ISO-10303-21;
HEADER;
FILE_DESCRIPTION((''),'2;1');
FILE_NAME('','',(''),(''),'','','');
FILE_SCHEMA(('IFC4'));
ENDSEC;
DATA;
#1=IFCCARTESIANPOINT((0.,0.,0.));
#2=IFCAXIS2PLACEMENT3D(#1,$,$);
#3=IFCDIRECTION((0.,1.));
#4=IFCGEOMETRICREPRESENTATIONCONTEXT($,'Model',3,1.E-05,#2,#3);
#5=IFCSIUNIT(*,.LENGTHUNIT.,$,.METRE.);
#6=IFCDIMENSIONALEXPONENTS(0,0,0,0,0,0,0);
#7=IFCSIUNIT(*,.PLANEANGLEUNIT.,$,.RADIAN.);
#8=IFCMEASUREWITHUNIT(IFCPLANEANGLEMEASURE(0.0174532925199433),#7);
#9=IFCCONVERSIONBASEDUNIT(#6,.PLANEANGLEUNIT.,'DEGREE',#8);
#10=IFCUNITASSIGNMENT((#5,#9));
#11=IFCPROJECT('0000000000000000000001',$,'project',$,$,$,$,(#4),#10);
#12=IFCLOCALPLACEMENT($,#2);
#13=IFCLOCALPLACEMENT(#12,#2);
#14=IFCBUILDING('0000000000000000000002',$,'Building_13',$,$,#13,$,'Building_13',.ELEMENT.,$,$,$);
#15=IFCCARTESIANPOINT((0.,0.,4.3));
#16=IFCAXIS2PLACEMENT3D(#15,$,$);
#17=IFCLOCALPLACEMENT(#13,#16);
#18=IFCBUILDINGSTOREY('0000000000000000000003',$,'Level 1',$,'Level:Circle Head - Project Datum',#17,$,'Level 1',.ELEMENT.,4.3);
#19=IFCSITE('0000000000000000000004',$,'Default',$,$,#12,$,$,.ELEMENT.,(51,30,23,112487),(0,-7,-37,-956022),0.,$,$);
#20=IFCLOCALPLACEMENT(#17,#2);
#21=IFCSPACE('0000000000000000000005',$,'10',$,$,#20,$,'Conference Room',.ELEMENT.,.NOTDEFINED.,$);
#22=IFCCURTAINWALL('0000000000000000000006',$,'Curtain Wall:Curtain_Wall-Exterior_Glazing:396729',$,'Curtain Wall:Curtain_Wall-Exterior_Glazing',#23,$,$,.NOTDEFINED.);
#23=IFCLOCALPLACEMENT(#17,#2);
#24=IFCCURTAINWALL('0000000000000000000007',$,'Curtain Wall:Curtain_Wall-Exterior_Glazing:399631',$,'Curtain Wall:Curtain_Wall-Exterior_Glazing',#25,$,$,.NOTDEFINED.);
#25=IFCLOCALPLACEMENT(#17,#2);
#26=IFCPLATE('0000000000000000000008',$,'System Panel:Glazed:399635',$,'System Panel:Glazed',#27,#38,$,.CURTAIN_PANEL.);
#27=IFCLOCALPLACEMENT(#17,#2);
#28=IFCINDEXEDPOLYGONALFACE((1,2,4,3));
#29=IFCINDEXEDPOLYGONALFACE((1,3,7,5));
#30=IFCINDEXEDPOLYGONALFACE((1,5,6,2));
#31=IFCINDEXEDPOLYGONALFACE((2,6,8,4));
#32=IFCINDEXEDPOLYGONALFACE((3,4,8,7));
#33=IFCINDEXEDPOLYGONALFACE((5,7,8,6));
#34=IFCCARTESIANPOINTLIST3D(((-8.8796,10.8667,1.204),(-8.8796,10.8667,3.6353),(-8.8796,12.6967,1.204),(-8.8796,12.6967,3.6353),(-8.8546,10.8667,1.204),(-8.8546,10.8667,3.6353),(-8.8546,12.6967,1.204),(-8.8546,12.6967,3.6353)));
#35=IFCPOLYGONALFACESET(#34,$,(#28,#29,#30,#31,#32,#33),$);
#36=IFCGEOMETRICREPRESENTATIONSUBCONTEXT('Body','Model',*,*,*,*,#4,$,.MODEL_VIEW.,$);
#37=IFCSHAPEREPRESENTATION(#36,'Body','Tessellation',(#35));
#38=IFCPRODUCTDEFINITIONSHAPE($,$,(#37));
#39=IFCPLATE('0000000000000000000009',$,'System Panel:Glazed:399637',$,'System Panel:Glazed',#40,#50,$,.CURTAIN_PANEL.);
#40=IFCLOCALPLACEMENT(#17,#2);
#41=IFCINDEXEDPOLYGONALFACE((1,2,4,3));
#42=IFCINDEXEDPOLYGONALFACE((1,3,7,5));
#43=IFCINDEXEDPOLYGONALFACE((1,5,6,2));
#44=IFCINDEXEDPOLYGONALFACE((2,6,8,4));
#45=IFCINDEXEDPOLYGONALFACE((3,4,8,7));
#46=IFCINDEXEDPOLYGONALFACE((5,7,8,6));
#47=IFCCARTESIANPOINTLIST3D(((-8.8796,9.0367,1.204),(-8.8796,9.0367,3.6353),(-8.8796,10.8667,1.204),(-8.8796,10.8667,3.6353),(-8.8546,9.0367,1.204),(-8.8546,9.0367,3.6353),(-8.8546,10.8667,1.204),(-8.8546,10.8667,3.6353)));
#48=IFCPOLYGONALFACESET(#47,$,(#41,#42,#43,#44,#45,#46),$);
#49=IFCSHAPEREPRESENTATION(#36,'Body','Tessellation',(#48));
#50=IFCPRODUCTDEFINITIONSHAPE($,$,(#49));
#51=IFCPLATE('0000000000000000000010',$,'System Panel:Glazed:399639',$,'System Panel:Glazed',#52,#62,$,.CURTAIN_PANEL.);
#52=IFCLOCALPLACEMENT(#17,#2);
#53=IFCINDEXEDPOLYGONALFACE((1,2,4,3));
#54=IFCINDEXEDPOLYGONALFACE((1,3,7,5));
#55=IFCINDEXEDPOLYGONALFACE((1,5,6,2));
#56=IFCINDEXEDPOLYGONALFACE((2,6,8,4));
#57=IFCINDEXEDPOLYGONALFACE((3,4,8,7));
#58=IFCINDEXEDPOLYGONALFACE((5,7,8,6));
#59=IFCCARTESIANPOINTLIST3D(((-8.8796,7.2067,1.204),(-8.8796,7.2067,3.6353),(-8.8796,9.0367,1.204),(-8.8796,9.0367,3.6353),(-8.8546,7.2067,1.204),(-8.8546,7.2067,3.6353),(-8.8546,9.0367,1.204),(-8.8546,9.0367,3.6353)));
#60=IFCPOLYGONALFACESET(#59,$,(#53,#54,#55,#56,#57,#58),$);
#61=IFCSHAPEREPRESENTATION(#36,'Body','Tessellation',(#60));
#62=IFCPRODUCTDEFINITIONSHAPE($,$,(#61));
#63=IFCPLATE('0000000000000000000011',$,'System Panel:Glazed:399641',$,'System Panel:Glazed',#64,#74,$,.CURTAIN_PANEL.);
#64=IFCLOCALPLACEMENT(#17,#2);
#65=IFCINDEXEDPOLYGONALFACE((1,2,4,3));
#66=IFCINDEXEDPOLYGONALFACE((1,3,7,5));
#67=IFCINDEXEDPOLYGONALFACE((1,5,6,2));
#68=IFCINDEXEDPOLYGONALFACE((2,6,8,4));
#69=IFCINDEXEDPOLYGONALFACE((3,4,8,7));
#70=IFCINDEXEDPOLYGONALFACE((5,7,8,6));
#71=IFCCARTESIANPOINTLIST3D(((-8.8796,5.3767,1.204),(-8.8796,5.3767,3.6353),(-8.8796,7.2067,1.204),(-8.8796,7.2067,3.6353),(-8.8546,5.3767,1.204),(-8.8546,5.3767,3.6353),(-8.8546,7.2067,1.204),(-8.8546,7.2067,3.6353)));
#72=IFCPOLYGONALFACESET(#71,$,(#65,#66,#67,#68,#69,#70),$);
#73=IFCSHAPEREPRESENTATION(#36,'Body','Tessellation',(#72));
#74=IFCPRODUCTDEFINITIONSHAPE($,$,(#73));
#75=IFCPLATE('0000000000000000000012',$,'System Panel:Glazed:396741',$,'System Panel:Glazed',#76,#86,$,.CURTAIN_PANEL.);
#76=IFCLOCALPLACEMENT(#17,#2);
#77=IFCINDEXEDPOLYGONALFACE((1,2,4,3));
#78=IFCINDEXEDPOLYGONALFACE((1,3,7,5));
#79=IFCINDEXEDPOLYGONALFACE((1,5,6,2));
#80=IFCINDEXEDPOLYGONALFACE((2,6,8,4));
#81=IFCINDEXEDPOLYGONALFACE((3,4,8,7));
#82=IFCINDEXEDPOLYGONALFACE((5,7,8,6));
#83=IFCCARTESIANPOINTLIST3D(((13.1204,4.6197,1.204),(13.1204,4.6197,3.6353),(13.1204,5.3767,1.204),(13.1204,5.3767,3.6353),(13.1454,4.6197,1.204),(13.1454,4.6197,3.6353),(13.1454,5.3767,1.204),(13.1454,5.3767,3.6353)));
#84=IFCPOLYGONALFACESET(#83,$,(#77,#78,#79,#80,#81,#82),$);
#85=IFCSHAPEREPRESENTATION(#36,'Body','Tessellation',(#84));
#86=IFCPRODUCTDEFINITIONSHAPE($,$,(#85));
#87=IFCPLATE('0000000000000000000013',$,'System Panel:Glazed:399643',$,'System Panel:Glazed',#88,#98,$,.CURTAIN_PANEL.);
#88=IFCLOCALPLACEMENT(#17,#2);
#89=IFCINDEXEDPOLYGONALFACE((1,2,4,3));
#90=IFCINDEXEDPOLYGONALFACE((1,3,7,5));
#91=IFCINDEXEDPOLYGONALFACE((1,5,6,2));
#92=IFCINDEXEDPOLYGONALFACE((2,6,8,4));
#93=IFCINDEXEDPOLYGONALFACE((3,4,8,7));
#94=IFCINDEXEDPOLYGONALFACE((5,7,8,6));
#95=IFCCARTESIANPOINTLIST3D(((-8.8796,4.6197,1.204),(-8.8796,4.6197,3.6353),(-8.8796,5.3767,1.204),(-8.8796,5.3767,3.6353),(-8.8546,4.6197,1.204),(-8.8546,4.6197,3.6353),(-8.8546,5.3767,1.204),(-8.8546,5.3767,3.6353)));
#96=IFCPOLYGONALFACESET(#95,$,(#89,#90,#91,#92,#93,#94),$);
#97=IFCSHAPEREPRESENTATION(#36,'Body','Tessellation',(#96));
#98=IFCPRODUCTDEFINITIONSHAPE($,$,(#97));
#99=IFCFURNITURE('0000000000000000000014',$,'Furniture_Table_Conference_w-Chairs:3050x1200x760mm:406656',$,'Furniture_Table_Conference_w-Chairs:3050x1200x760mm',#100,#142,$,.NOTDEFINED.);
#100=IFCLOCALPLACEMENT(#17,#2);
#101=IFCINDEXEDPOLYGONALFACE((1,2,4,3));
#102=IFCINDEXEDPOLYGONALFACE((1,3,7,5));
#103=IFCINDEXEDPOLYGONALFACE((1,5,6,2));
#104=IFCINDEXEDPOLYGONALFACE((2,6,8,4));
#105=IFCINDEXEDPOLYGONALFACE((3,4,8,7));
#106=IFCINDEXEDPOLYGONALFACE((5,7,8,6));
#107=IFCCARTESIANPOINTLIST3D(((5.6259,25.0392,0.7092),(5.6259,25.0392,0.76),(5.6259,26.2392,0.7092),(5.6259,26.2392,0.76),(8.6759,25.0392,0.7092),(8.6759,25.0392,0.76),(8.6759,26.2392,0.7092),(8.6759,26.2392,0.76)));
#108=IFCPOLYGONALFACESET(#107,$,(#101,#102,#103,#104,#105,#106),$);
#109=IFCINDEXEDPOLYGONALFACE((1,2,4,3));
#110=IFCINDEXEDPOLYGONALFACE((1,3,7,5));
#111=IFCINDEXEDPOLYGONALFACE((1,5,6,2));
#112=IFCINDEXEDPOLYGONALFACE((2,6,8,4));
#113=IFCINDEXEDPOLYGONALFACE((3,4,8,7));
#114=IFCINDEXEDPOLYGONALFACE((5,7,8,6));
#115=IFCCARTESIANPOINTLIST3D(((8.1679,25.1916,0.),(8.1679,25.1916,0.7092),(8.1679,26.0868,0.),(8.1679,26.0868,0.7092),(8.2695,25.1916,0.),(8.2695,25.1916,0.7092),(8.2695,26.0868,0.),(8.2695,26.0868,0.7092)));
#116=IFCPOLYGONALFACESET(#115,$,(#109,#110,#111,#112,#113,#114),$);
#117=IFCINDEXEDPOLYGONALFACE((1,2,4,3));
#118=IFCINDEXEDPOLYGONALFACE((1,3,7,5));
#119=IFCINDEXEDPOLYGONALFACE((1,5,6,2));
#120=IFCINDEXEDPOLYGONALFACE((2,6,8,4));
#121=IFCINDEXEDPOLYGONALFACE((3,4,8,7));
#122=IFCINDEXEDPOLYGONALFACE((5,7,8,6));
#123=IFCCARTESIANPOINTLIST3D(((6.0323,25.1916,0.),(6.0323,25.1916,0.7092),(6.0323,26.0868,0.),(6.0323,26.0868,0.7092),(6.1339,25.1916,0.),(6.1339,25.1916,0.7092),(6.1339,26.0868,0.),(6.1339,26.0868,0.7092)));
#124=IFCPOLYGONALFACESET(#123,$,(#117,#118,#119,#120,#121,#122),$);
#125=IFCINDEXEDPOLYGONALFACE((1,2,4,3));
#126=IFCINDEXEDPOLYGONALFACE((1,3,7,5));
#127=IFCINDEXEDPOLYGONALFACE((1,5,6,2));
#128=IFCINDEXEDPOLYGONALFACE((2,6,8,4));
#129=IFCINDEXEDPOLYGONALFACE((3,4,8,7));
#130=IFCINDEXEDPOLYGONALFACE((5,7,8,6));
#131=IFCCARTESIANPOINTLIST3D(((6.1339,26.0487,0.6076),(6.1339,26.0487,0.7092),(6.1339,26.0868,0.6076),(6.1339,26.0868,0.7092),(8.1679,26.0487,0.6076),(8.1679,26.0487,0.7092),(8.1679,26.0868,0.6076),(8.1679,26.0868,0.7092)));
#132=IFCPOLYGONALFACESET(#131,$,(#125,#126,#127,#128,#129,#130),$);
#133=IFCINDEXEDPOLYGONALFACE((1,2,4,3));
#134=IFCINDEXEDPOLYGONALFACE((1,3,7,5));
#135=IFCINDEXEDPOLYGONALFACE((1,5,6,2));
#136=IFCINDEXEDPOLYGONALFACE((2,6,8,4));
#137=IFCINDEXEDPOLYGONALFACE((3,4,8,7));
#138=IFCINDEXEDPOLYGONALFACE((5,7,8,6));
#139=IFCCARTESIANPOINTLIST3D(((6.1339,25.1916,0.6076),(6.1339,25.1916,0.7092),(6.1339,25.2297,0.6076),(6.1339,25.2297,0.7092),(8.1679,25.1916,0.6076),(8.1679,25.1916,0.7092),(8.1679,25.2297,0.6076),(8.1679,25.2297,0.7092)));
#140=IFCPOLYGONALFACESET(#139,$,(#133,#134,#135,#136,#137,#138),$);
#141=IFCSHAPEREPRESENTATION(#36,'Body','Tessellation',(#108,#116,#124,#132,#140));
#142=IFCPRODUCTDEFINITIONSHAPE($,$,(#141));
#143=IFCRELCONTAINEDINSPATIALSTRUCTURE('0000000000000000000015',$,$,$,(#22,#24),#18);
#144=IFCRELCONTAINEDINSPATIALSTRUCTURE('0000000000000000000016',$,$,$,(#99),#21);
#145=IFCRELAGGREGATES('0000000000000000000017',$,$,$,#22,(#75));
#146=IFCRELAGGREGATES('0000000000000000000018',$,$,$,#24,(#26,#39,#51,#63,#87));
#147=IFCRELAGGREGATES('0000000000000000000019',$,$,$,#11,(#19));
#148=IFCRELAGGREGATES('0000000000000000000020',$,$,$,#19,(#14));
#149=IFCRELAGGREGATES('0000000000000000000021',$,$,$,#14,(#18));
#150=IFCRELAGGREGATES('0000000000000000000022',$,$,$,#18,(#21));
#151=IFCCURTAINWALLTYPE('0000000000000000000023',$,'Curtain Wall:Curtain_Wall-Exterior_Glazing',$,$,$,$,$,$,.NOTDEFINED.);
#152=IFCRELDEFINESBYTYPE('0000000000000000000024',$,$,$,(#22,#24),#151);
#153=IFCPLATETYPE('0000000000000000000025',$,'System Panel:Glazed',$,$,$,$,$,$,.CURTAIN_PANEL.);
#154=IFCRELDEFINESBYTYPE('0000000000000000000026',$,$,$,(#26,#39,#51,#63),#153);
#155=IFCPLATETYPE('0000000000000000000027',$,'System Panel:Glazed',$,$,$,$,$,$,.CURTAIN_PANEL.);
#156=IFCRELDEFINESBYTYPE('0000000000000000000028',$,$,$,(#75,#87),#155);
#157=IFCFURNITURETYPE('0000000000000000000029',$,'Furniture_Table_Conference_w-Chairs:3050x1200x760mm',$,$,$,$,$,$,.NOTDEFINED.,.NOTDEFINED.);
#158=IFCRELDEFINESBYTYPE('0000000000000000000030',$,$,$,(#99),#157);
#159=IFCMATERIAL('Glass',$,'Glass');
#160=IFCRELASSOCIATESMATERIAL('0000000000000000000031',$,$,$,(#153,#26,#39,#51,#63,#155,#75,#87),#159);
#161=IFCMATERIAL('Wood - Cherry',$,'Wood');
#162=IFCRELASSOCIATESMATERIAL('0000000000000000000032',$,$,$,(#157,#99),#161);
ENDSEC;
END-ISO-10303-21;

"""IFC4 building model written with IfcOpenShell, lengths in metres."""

from ifc_helpers import new_model, entity, si_unit, converted_unit, direction, frame, origin, place, context, subcontext, project, spatial, indexed_curve, outline, extrude, source, transform, mapped, material, type_object, type_shapes, element, aggregate, save


model = new_model("IFC4")

# Units and contexts
model_context = context("Model", 3, precision=1e-05, world=origin(), true_north=direction((0.0, 1.0)))
body_context = subcontext(model_context, "Body", "Model", "MODEL_VIEW")
ifc_project = project(units=[si_unit("LENGTHUNIT", "METRE"), converted_unit("PLANEANGLEUNIT", "DEGREE", entity("IfcPlaneAngleMeasure", 0.0174532925199433), si_unit("PLANEANGLEUNIT", "RADIAN"), dimensions=[0, 0, 0, 0, 0, 0, 0])], contexts=[model_context])

# Site, building, storey
site_placement = place(None, origin())
site = spatial("IfcSite", under=ifc_project, at=site_placement, Name="Default", CompositionType="ELEMENT", RefLatitude=(51, 30, 23, 112487), RefLongitude=(0, -7, -37, -956022), RefElevation=0.0)
building_placement = place(site_placement, origin())
building = spatial("IfcBuilding", under=site, at=building_placement, Name="Building_13", LongName="Building_13", CompositionType="ELEMENT")
storey_placement = place(building_placement, frame((0.0, 0.0, 4.3)))
storey = spatial("IfcBuildingStorey", under=building, at=storey_placement, Name="Level 1", ObjectType="Level:Circle Head - Project Datum", LongName="Level 1", CompositionType="ELEMENT", Elevation=4.3)

# Curtain walls, plates
curtain_wall_type = type_object("IfcCurtainWallType", Name="Curtain Wall:Curtain_Wall-Exterior_Glazing", PredefinedType="NOTDEFINED")
curtain_wall_1_placement = place(storey_placement, frame((0.0, 0.0, -4.3)))
curtain_wall_1 = element("IfcCurtainWall", 1, at=curtain_wall_1_placement, inside=storey, type_object=curtain_wall_type, Name="Curtain Wall:Curtain_Wall-Exterior_Glazing:396729", ObjectType="Curtain Wall:Curtain_Wall-Exterior_Glazing", PredefinedType="NOTDEFINED")
ifc_material_1 = material(Name="Glass", Category="Glass")
plate_type_1 = type_object("IfcPlateType", Name="System Panel:Glazed", PredefinedType="CURTAIN_PANEL", material=ifc_material_1)
shared_shape_1 = source(origin(), body_context, "Body", "SweptSolid", [
    extrude(outline(indexed_curve([(-0.0125, -0.915), (0.0125, -0.915), (0.0125, 0.915), (-0.0125, 0.915), (-0.0125, -0.915)], self_intersect=False)), frame((0.0, 0.037, 0.0), z_axis=(0.0, 0.0, 1.0), x_axis=(0.0, 1.0, 0.0)), (0.0, 0.0, 1.0), 2.4313),
])
type_shapes(plate_type_1, [shared_shape_1])
curtain_wall_2_placement = place(storey_placement, frame((0.0, 0.0, -4.3)))
curtain_wall_2 = element("IfcCurtainWall", 2, at=curtain_wall_2_placement, inside=storey, type_object=curtain_wall_type, Name="Curtain Wall:Curtain_Wall-Exterior_Glazing:399631", ObjectType="Curtain Wall:Curtain_Wall-Exterior_Glazing", PredefinedType="NOTDEFINED")
plate_1_placement = place(curtain_wall_2_placement, frame((-8.9041, 11.7817, 5.504), z_axis=(0.0, 0.0, 1.0), x_axis=(0.0, -1.0, 0.0)))
plate_1 = element("IfcPlate", 3, at=plate_1_placement, type_object=plate_type_1, material=ifc_material_1, Name="System Panel:Glazed:399635", ObjectType="System Panel:Glazed", PredefinedType="CURTAIN_PANEL", context=body_context, shape_type="MappedRepresentation", body=[
    mapped(shared_shape_1, transform((0.0, 0.0, 0.0), scale=1.0)),
])
plate_2_placement = place(curtain_wall_2_placement, frame((-8.9041, 9.9517, 5.504), z_axis=(0.0, 0.0, 1.0), x_axis=(0.0, -1.0, 0.0)))
plate_2 = element("IfcPlate", 4, at=plate_2_placement, type_object=plate_type_1, material=ifc_material_1, Name="System Panel:Glazed:399637", ObjectType="System Panel:Glazed", PredefinedType="CURTAIN_PANEL", context=body_context, shape_type="MappedRepresentation", body=[
    mapped(shared_shape_1, transform((0.0, 0.0, 0.0), scale=1.0)),
])
plate_3_placement = place(curtain_wall_2_placement, frame((-8.9041, 8.1217, 5.504), z_axis=(0.0, 0.0, 1.0), x_axis=(0.0, -1.0, 0.0)))
plate_3 = element("IfcPlate", 5, at=plate_3_placement, type_object=plate_type_1, material=ifc_material_1, Name="System Panel:Glazed:399639", ObjectType="System Panel:Glazed", PredefinedType="CURTAIN_PANEL", context=body_context, shape_type="MappedRepresentation", body=[
    mapped(shared_shape_1, transform((0.0, 0.0, 0.0), scale=1.0)),
])
plate_4_placement = place(curtain_wall_2_placement, frame((-8.9041, 6.2917, 5.504), z_axis=(0.0, 0.0, 1.0), x_axis=(0.0, -1.0, 0.0)))
plate_4 = element("IfcPlate", 6, at=plate_4_placement, type_object=plate_type_1, material=ifc_material_1, Name="System Panel:Glazed:399641", ObjectType="System Panel:Glazed", PredefinedType="CURTAIN_PANEL", context=body_context, shape_type="MappedRepresentation", body=[
    mapped(shared_shape_1, transform((0.0, 0.0, 0.0), scale=1.0)),
])

# Plates
plate_type_2 = type_object("IfcPlateType", Name="System Panel:Glazed", PredefinedType="CURTAIN_PANEL", material=ifc_material_1)
shared_shape_2 = source(origin(), body_context, "Body", "SweptSolid", [
    extrude(outline(indexed_curve([(-0.0125, -0.3785), (0.0125, -0.3785), (0.0125, 0.3785), (-0.0125, 0.3785), (-0.0125, -0.3785)], self_intersect=False)), frame((0.0, 0.037, 0.0), z_axis=(0.0, 0.0, 1.0), x_axis=(0.0, 1.0, 0.0)), (0.0, 0.0, 1.0), 2.4313),
])
type_shapes(plate_type_2, [shared_shape_2])
plate_5_placement = place(curtain_wall_1_placement, frame((13.0959, 4.9982, 5.504), z_axis=(0.0, 0.0, 1.0), x_axis=(0.0, -1.0, 0.0)))
plate_5 = element("IfcPlate", 7, at=plate_5_placement, type_object=plate_type_2, material=ifc_material_1, Name="System Panel:Glazed:396741", ObjectType="System Panel:Glazed", PredefinedType="CURTAIN_PANEL", context=body_context, shape_type="MappedRepresentation", body=[
    mapped(shared_shape_2, transform((0.0, 0.0, 0.0), scale=1.0)),
])
aggregate(curtain_wall_1, [plate_5])
plate_6_placement = place(curtain_wall_2_placement, frame((-8.9041, 4.9982, 5.504), z_axis=(0.0, 0.0, 1.0), x_axis=(0.0, -1.0, 0.0)))
plate_6 = element("IfcPlate", 8, at=plate_6_placement, type_object=plate_type_2, material=ifc_material_1, Name="System Panel:Glazed:399643", ObjectType="System Panel:Glazed", PredefinedType="CURTAIN_PANEL", context=body_context, shape_type="MappedRepresentation", body=[
    mapped(shared_shape_2, transform((0.0, 0.0, 0.0), scale=1.0)),
])
aggregate(curtain_wall_2, [plate_1, plate_2, plate_3, plate_4, plate_6])

# Shared definitions
space_placement = place(storey_placement, origin())
space = spatial("IfcSpace", under=storey, at=space_placement, Name="10", LongName="Conference Room", CompositionType="ELEMENT", PredefinedType="NOTDEFINED")

# Furniture
ifc_material_2 = material(Name="Wood - Cherry", Category="Wood")
furniture_type_1 = type_object("IfcFurnitureType", Name="Furniture_Table_Conference_w-Chairs:3050x1200x760mm", AssemblyPlace="NOTDEFINED", PredefinedType="NOTDEFINED", material=ifc_material_2)
shared_shape_3 = source(origin(), body_context, "Body", "SweptSolid", [
    extrude(outline(indexed_curve([(-0.6, -1.525), (0.6, -1.525), (0.6, 1.525), (-0.6, 1.525), (-0.6, -1.525)], self_intersect=False)), frame((0.0, 0.0, 0.7092), z_axis=(0.0, 0.0, 1.0), x_axis=(0.0, 1.0, 0.0)), (0.0, 0.0, 1.0), 0.0508),
    extrude(outline(indexed_curve([(-0.4476, -0.0508), (0.4476, -0.0508), (0.4476, 0.0508), (-0.4476, 0.0508), (-0.4476, -0.0508)], self_intersect=False)), frame((1.0678, 0.0, 0.0), z_axis=(0.0, 0.0, 1.0), x_axis=(0.0, 1.0, 0.0)), (0.0, 0.0, 1.0), 0.7092),
    extrude(outline(indexed_curve([(-0.4476, -0.0508), (0.4476, -0.0508), (0.4476, 0.0508), (-0.4476, 0.0508), (-0.4476, -0.0508)], self_intersect=False)), frame((-1.0678, 0.0, 0.0), z_axis=(0.0, 0.0, 1.0), x_axis=(0.0, 1.0, 0.0)), (0.0, 0.0, 1.0), 0.7092),
    extrude(outline(indexed_curve([(-1.017, -0.0191), (1.017, -0.0191), (1.017, 0.0191), (-1.017, 0.0191), (-1.017, -0.0191)], self_intersect=False)), frame((0.0, 0.4286, 0.6076), z_axis=(0.0, 0.0, 1.0), x_axis=(-1.0, 0.0, 0.0)), (0.0, 0.0, 1.0), 0.1016),
    extrude(outline(indexed_curve([(-0.019, -1.017), (0.019, -1.017), (0.019, 1.017), (-0.019, 1.017), (-0.019, -1.017)], self_intersect=False)), frame((0.0, -0.4286, 0.6076), z_axis=(0.0, 0.0, 1.0), x_axis=(0.0, 1.0, 0.0)), (0.0, 0.0, 1.0), 0.1016),
])
type_shapes(furniture_type_1, [shared_shape_3])
furniture_1_placement = place(space_placement, frame((7.1509, 25.6392, 0.0)))
element("IfcFurniture", 9, at=furniture_1_placement, inside=space, type_object=furniture_type_1, material=ifc_material_2, Name="Furniture_Table_Conference_w-Chairs:3050x1200x760mm:406656", ObjectType="Furniture_Table_Conference_w-Chairs:3050x1200x760mm", PredefinedType="NOTDEFINED", context=body_context, shape_type="MappedRepresentation", body=[
    mapped(shared_shape_3, transform((0.0, 0.0, 0.0), scale=1.0)),
])

save(model, "model.ifc")
